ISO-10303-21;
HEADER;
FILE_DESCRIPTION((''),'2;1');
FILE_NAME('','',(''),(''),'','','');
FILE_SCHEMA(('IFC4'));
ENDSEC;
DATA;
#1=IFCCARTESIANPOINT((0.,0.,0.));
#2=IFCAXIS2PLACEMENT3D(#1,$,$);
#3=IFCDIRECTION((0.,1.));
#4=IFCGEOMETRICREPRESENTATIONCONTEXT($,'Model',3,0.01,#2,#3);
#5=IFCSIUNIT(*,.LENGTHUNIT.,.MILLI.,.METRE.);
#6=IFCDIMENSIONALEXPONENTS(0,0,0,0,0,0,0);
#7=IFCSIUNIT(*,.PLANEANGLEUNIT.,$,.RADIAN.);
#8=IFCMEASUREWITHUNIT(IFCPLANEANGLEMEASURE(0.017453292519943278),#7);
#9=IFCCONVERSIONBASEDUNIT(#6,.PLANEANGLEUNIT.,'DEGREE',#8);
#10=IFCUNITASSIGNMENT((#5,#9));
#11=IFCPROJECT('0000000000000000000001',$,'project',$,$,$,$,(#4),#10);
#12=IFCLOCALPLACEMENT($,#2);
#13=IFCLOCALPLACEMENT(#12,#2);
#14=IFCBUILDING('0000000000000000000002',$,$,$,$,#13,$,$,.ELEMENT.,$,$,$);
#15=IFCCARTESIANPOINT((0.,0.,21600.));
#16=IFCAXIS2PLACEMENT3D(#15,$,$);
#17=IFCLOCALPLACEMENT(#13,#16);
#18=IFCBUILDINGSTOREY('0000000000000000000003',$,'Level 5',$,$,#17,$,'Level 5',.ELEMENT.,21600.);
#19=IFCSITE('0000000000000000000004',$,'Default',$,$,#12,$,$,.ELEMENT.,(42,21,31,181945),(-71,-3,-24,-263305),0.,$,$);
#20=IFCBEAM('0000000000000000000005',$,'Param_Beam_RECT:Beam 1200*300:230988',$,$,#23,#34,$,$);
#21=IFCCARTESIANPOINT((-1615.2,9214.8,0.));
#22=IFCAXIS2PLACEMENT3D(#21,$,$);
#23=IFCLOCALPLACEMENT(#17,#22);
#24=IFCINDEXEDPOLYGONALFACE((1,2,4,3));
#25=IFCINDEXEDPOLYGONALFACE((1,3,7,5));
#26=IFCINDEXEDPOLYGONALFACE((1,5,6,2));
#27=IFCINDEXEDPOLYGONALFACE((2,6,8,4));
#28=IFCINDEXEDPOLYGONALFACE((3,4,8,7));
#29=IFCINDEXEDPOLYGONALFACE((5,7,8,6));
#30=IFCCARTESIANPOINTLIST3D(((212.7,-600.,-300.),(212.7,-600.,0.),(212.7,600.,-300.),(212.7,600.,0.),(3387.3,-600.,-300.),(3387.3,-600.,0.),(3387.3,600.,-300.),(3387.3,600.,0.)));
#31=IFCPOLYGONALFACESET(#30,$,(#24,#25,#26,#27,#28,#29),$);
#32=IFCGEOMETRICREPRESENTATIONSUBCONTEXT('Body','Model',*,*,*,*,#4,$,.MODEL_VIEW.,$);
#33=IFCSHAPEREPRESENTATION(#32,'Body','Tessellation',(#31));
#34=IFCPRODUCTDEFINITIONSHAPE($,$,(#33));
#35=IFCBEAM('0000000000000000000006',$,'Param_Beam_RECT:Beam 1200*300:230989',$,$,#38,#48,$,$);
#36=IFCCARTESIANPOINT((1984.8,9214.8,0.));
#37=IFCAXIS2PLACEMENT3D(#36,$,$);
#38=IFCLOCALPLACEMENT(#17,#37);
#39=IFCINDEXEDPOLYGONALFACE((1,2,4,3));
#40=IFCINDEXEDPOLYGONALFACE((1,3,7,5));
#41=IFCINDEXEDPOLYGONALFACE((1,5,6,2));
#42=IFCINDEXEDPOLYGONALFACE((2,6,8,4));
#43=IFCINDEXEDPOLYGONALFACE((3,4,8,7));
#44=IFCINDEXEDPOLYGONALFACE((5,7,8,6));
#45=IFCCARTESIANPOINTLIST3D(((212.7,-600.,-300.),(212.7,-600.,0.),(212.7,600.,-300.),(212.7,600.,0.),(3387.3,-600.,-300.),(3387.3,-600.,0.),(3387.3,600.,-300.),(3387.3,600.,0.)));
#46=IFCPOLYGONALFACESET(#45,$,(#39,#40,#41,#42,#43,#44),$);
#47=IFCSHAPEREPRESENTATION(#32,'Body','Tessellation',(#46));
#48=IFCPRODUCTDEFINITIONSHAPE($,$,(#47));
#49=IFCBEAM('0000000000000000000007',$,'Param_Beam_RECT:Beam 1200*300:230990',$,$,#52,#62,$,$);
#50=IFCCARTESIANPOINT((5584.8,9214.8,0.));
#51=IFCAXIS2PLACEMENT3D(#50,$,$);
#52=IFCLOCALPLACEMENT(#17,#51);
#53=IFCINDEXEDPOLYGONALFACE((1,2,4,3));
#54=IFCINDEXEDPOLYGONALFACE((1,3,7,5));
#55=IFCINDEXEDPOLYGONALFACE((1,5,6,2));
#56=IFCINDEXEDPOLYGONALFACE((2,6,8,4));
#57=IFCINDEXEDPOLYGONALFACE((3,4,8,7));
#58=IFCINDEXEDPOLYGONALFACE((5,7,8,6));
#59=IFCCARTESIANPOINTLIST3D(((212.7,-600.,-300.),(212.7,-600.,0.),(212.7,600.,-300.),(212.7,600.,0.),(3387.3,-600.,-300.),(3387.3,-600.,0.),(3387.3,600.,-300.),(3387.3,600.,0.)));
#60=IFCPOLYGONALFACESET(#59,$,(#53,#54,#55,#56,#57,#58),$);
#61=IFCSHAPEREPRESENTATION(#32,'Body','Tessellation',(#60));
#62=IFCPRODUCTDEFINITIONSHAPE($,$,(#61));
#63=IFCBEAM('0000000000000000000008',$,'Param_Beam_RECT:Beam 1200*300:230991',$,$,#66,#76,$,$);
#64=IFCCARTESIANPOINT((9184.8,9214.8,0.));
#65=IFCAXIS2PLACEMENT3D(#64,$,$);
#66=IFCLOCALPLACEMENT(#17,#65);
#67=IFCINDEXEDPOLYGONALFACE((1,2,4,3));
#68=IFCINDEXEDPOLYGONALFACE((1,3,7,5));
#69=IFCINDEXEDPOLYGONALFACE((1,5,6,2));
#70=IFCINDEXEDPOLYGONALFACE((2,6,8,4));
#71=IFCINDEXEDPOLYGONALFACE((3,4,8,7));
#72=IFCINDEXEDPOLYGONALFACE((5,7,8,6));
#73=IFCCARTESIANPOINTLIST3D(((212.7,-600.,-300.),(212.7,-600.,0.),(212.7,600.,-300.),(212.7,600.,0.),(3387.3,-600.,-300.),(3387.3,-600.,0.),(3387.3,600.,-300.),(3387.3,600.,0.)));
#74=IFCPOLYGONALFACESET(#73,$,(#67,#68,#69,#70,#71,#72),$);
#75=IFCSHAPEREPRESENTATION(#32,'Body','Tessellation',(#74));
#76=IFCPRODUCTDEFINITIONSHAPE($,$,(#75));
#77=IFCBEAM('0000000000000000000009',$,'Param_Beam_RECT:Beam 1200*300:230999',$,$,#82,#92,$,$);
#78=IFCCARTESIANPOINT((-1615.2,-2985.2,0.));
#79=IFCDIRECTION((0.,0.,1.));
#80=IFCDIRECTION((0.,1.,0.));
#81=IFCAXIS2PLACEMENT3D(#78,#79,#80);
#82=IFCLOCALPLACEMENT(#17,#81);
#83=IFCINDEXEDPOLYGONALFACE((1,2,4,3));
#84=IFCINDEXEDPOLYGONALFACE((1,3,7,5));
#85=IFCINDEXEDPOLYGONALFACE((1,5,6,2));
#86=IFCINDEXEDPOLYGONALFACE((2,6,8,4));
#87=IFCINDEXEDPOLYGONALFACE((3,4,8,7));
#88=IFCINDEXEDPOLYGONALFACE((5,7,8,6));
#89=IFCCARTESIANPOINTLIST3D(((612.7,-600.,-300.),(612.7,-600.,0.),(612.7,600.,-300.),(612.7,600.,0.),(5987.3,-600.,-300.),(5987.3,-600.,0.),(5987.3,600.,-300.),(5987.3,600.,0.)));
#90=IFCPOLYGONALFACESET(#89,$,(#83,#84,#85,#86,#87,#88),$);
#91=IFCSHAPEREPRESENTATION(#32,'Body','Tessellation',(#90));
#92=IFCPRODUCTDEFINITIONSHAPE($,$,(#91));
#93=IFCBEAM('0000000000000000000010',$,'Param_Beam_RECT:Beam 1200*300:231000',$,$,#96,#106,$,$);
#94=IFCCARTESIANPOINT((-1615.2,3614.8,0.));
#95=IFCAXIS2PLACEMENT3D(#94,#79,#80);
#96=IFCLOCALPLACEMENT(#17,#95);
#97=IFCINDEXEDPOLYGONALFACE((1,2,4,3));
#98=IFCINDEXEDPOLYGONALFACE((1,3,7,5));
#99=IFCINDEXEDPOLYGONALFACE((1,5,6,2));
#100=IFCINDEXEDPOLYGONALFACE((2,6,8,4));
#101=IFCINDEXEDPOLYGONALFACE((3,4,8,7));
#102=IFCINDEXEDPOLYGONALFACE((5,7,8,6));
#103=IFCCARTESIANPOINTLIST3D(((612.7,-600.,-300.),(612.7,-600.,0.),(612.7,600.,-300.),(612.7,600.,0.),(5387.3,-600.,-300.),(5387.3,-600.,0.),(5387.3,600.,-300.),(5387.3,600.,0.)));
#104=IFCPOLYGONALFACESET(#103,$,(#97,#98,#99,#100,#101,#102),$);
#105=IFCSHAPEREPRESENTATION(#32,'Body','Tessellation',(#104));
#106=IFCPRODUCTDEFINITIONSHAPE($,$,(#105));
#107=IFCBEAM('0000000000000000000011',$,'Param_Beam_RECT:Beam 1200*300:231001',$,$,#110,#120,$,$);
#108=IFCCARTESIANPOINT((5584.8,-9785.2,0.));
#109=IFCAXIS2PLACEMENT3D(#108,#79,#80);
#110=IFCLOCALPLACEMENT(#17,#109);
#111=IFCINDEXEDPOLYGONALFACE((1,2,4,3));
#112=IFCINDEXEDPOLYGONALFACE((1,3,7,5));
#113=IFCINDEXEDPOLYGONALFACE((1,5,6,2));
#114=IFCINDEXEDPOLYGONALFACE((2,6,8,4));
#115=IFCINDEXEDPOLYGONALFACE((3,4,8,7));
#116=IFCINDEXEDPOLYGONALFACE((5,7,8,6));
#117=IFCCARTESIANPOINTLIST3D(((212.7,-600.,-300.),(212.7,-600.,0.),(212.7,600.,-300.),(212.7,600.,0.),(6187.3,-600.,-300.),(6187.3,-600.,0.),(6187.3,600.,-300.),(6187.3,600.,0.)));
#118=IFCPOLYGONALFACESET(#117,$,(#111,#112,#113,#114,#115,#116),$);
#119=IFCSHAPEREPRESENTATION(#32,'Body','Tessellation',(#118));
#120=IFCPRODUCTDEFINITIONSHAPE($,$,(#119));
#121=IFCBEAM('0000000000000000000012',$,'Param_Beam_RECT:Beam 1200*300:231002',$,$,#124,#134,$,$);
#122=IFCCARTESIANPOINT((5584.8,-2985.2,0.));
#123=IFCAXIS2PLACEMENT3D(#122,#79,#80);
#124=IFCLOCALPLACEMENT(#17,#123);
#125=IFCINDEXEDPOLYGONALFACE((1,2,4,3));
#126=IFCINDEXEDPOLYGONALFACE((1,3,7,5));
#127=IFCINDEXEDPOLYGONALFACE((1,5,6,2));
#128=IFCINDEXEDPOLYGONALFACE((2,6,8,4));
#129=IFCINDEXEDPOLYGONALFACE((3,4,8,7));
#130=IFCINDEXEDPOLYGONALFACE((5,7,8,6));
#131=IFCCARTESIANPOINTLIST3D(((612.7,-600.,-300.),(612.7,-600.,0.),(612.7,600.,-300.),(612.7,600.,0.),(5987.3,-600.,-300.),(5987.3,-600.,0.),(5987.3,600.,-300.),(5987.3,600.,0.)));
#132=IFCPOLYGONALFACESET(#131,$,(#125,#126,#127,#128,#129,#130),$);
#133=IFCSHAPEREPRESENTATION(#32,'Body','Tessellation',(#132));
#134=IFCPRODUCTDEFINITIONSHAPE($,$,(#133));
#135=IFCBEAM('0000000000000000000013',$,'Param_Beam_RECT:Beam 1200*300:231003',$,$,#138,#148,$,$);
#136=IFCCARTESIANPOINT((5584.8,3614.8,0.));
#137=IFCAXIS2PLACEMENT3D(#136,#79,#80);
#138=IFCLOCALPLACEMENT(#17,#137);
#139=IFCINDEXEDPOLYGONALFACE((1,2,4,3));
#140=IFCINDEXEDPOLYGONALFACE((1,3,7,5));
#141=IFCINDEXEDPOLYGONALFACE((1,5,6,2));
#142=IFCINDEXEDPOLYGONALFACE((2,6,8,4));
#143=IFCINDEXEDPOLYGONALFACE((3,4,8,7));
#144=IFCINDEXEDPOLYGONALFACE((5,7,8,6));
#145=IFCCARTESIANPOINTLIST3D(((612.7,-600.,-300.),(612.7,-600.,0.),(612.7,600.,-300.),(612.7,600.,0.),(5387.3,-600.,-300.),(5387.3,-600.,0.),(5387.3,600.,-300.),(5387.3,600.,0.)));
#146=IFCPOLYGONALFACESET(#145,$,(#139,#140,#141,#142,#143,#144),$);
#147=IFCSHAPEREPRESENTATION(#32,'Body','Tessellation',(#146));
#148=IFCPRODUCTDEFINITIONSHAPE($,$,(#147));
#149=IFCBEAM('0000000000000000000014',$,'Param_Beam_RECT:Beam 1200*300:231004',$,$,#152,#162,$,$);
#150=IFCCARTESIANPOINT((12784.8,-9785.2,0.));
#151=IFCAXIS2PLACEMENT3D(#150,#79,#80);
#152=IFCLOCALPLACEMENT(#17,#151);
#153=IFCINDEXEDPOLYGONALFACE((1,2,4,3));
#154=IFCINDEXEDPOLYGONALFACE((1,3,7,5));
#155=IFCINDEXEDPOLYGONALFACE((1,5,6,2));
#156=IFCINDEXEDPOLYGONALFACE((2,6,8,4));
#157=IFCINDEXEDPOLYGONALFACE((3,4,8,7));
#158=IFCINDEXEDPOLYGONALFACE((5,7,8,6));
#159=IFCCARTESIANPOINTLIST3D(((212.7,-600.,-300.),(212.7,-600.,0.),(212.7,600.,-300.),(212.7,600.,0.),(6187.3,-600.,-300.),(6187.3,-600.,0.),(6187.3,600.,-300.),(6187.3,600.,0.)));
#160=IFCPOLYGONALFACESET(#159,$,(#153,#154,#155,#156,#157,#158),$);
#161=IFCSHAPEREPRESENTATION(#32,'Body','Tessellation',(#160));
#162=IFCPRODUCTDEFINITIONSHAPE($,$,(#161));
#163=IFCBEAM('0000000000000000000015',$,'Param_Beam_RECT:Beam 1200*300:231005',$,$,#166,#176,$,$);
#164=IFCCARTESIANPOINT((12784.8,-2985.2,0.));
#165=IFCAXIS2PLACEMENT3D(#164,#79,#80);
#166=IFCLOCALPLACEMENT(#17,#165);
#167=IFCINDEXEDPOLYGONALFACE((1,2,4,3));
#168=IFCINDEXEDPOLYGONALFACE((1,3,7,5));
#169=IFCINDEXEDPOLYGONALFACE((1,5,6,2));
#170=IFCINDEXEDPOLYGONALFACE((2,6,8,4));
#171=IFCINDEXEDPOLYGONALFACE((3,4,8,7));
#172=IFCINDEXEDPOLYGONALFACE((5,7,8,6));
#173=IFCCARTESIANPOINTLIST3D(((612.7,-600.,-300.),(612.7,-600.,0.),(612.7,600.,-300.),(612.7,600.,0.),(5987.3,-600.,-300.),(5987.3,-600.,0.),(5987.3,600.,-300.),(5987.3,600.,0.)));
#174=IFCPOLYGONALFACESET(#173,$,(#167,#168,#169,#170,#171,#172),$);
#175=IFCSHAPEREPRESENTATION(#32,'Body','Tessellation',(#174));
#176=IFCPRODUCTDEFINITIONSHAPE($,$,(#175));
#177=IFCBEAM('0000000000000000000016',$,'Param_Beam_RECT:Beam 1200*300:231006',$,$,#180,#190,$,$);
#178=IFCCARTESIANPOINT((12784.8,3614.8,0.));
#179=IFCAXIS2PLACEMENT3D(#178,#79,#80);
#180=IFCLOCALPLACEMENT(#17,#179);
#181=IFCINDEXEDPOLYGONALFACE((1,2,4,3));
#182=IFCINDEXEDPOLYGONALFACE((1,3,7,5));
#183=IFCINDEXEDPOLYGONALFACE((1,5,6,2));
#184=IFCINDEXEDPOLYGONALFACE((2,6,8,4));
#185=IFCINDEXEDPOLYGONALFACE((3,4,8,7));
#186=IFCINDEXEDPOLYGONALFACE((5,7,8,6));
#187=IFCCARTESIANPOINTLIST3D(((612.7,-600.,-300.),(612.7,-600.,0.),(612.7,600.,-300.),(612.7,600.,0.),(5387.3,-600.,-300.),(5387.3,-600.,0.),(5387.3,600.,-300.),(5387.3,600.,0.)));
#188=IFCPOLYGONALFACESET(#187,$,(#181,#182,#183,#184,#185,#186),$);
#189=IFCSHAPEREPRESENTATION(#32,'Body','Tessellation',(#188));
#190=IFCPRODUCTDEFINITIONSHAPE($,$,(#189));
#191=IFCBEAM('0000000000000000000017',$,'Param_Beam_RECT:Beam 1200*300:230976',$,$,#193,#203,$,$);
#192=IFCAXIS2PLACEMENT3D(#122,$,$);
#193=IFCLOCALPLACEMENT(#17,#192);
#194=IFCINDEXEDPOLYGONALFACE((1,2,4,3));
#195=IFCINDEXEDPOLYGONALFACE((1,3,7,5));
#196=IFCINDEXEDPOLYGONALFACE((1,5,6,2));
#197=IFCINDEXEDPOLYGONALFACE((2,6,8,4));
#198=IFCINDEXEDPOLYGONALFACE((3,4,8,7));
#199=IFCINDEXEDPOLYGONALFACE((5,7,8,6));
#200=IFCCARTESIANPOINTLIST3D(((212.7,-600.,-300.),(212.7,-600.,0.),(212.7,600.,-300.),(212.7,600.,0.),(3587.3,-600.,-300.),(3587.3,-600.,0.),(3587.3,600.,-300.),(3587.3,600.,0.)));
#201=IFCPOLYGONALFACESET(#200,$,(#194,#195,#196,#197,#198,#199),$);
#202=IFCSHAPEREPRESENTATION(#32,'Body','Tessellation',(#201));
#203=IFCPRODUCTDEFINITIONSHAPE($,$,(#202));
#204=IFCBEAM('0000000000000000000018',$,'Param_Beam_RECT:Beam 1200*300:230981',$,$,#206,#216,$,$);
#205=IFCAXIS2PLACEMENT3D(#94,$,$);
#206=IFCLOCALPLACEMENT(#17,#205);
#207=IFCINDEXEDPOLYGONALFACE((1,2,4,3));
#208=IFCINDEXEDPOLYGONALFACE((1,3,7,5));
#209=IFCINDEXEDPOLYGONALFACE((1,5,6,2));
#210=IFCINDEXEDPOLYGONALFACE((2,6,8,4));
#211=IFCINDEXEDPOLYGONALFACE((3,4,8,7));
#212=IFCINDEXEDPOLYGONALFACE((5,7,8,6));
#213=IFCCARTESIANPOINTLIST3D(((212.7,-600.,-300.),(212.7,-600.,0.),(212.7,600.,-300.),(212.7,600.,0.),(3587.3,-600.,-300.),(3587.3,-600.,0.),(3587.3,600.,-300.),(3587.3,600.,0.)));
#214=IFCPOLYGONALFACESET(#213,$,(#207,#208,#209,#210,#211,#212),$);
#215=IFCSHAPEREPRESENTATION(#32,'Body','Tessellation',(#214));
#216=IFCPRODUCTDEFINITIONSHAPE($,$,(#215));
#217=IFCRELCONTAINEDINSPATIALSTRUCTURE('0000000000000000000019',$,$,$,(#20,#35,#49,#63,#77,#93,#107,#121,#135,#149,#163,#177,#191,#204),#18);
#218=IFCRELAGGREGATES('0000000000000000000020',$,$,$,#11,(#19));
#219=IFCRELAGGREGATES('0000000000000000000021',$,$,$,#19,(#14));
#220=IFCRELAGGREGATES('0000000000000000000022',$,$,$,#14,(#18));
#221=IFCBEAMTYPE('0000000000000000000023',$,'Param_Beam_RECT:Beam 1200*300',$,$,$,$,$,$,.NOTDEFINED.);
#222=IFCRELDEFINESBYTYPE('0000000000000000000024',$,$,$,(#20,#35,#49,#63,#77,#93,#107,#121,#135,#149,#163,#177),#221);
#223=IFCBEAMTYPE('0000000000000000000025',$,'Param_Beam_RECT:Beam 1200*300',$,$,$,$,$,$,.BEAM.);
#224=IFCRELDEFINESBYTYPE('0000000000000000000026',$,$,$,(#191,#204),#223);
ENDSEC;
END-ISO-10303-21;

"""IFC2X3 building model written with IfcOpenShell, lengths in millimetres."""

from ifc_helpers import new_model, entity, si_unit, converted_unit, direction, frame, frame_2d, origin, origin_2d_with_axis, place, context, subcontext, project, spatial, rectangle, extrude, type_object, element, save


model = new_model("IFC2X3")

# Units and contexts
model_context = context("Model", 3, precision=0.01, world=origin(), true_north=direction((0.0, 1.0)))
body_context = subcontext(model_context, "Body", "Model", "MODEL_VIEW")
ifc_project = project(units=[si_unit("LENGTHUNIT", "METRE", prefix="MILLI"), converted_unit("PLANEANGLEUNIT", "DEGREE", entity("IfcPlaneAngleMeasure", 0.017453292519943278), si_unit("PLANEANGLEUNIT", "RADIAN"), dimensions=[0, 0, 0, 0, 0, 0, 0])], contexts=[model_context])

# Site, building, storey
site_placement = place(None, origin())
site = spatial("IfcSite", under=ifc_project, at=site_placement, Name="Default", CompositionType="ELEMENT", RefLatitude=(42, 21, 31, 181945), RefLongitude=(-71, -3, -24, -263305), RefElevation=0.0)
building_placement = place(site_placement, origin())
building = spatial("IfcBuilding", under=site, at=building_placement, CompositionType="ELEMENT")
storey_placement = place(building_placement, frame((0.0, 0.0, 21600.0)))
storey = spatial("IfcBuildingStorey", under=building, at=storey_placement, Name="Level 5", LongName="Level 5", CompositionType="ELEMENT", Elevation=21600.0)

# Beams
beam_type_1 = type_object("IfcBeamType", Name="Param_Beam_RECT:Beam 1200*300", PredefinedType="NOTDEFINED")
beam_1_placement = place(storey_placement, frame((-1615.2, 9214.8, 0.0)))
element("IfcBeam", 1, at=beam_1_placement, inside=storey, type_object=beam_type_1, Name="Param_Beam_RECT:Beam 1200*300:230988", context=body_context, shape_type="SweptSolid", body=[
    extrude(rectangle(XDim=300.0, YDim=1200.0, at=frame_2d((0.0, 0.0), x_axis=(1.0, 0.0))), frame((212.7, 0.0, -150.0), z_axis=(1.0, 0.0, 0.0), x_axis=(0.0, 0.0, -1.0)), (0.0, 0.0, 1.0), 3174.6),
])
beam_2_placement = place(storey_placement, frame((1984.8, 9214.8, 0.0)))
element("IfcBeam", 2, at=beam_2_placement, inside=storey, type_object=beam_type_1, Name="Param_Beam_RECT:Beam 1200*300:230989", context=body_context, shape_type="SweptSolid", body=[
    extrude(rectangle(XDim=300.0, YDim=1200.0, at=origin_2d_with_axis()), frame((212.7, 0.0, -150.0), z_axis=(1.0, 0.0, 0.0), x_axis=(0.0, 0.0, -1.0)), (0.0, 0.0, 1.0), 3174.6),
])
for number, where, name in (
    (3, (5584.8, 9214.8, 0.0), "Param_Beam_RECT:Beam 1200*300:230990"),
    (4, (9184.8, 9214.8, 0.0), "Param_Beam_RECT:Beam 1200*300:230991"),
):
    element("IfcBeam", number, at=place(storey_placement, frame(where)), inside=storey, type_object=beam_type_1, Name=name, context=body_context, shape_type="SweptSolid", body=[
        extrude(rectangle(XDim=300.0, YDim=1200.0, at=frame_2d((0.0, 0.0), x_axis=(1.0, 0.0))), frame((212.7, 0.0, -150.0), z_axis=(1.0, 0.0, 0.0), x_axis=(0.0, 0.0, -1.0)), (0.0, 0.0, 1.0), 3174.6),
    ])
beam_3_placement = place(storey_placement, frame((-1615.2, -2985.2, 0.0), z_axis=(0.0, 0.0, 1.0), x_axis=(0.0, 1.0, 0.0)))
element("IfcBeam", 5, at=beam_3_placement, inside=storey, type_object=beam_type_1, Name="Param_Beam_RECT:Beam 1200*300:230999", context=body_context, shape_type="SweptSolid", body=[
    extrude(rectangle(XDim=300.0, YDim=1200.0, at=frame_2d((0.0, 0.0), x_axis=(1.0, 0.0))), frame((612.7, 0.0, -150.0), z_axis=(1.0, 0.0, 0.0), x_axis=(0.0, 0.0, -1.0)), (0.0, 0.0, 1.0), 5374.6),
])
beam_4_placement = place(storey_placement, frame((-1615.2, 3614.8, 0.0), z_axis=(0.0, 0.0, 1.0), x_axis=(0.0, 1.0, 0.0)))
element("IfcBeam", 6, at=beam_4_placement, inside=storey, type_object=beam_type_1, Name="Param_Beam_RECT:Beam 1200*300:231000", context=body_context, shape_type="SweptSolid", body=[
    extrude(rectangle(XDim=300.0, YDim=1200.0, at=frame_2d((0.0, 0.0), x_axis=(1.0, 0.0))), frame((612.7, 0.0, -150.0), z_axis=(1.0, 0.0, 0.0), x_axis=(0.0, 0.0, -1.0)), (0.0, 0.0, 1.0), 4774.6),
])
beam_5_placement = place(storey_placement, frame((5584.8, -9785.2, 0.0), z_axis=(0.0, 0.0, 1.0), x_axis=(0.0, 1.0, 0.0)))
element("IfcBeam", 7, at=beam_5_placement, inside=storey, type_object=beam_type_1, Name="Param_Beam_RECT:Beam 1200*300:231001", context=body_context, shape_type="SweptSolid", body=[
    extrude(rectangle(XDim=300.0, YDim=1200.0, at=frame_2d((0.0, 0.0), x_axis=(1.0, 0.0))), frame((212.7, 0.0, -150.0), z_axis=(1.0, 0.0, 0.0), x_axis=(0.0, 0.0, -1.0)), (0.0, 0.0, 1.0), 5974.6),
])
beam_6_placement = place(storey_placement, frame((5584.8, -2985.2, 0.0), z_axis=(0.0, 0.0, 1.0), x_axis=(0.0, 1.0, 0.0)))
element("IfcBeam", 8, at=beam_6_placement, inside=storey, type_object=beam_type_1, Name="Param_Beam_RECT:Beam 1200*300:231002", context=body_context, shape_type="SweptSolid", body=[
    extrude(rectangle(XDim=300.0, YDim=1200.0, at=frame_2d((0.0, 0.0), x_axis=(1.0, 0.0))), frame((612.7, 0.0, -150.0), z_axis=(1.0, 0.0, 0.0), x_axis=(0.0, 0.0, -1.0)), (0.0, 0.0, 1.0), 5374.6),
])
beam_7_placement = place(storey_placement, frame((5584.8, 3614.8, 0.0), z_axis=(0.0, 0.0, 1.0), x_axis=(0.0, 1.0, 0.0)))
element("IfcBeam", 9, at=beam_7_placement, inside=storey, type_object=beam_type_1, Name="Param_Beam_RECT:Beam 1200*300:231003", context=body_context, shape_type="SweptSolid", body=[
    extrude(rectangle(XDim=300.0, YDim=1200.0, at=frame_2d((0.0, 0.0), x_axis=(1.0, 0.0))), frame((612.7, 0.0, -150.0), z_axis=(1.0, 0.0, 0.0), x_axis=(0.0, 0.0, -1.0)), (0.0, 0.0, 1.0), 4774.6),
])
beam_8_placement = place(storey_placement, frame((12784.8, -9785.2, 0.0), z_axis=(0.0, 0.0, 1.0), x_axis=(0.0, 1.0, 0.0)))
element("IfcBeam", 10, at=beam_8_placement, inside=storey, type_object=beam_type_1, Name="Param_Beam_RECT:Beam 1200*300:231004", context=body_context, shape_type="SweptSolid", body=[
    extrude(rectangle(XDim=300.0, YDim=1200.0, at=origin_2d_with_axis()), frame((212.7, 0.0, -150.0), z_axis=(1.0, 0.0, 0.0), x_axis=(0.0, 0.0, -1.0)), (0.0, 0.0, 1.0), 5974.6),
])
beam_9_placement = place(storey_placement, frame((12784.8, -2985.2, 0.0), z_axis=(0.0, 0.0, 1.0), x_axis=(0.0, 1.0, 0.0)))
element("IfcBeam", 11, at=beam_9_placement, inside=storey, type_object=beam_type_1, Name="Param_Beam_RECT:Beam 1200*300:231005", context=body_context, shape_type="SweptSolid", body=[
    extrude(rectangle(XDim=300.0, YDim=1200.0, at=frame_2d((0.0, 0.0), x_axis=(1.0, 0.0))), frame((612.7, 0.0, -150.0), z_axis=(1.0, 0.0, 0.0), x_axis=(0.0, 0.0, -1.0)), (0.0, 0.0, 1.0), 5374.6),
])
beam_10_placement = place(storey_placement, frame((12784.8, 3614.8, 0.0), z_axis=(0.0, 0.0, 1.0), x_axis=(0.0, 1.0, 0.0)))
element("IfcBeam", 12, at=beam_10_placement, inside=storey, type_object=beam_type_1, Name="Param_Beam_RECT:Beam 1200*300:231006", context=body_context, shape_type="SweptSolid", body=[
    extrude(rectangle(XDim=300.0, YDim=1200.0, at=origin_2d_with_axis()), frame((612.7, 0.0, -150.0), z_axis=(1.0, 0.0, 0.0), x_axis=(0.0, 0.0, -1.0)), (0.0, 0.0, 1.0), 4774.6),
])
beam_type_2 = type_object("IfcBeamType", Name="Param_Beam_RECT:Beam 1200*300", PredefinedType="BEAM")
beam_11_placement = place(storey_placement, frame((5584.8, -2985.2, 0.0)))
element("IfcBeam", 13, at=beam_11_placement, inside=storey, type_object=beam_type_2, Name="Param_Beam_RECT:Beam 1200*300:230976", context=body_context, shape_type="SweptSolid", body=[
    extrude(rectangle(XDim=300.0, YDim=1200.0, at=frame_2d((0.0, 0.0), x_axis=(1.0, 0.0))), frame((212.7, 0.0, -150.0), z_axis=(1.0, 0.0, 0.0), x_axis=(0.0, 0.0, -1.0)), (0.0, 0.0, 1.0), 3374.6),
])
beam_12_placement = place(storey_placement, frame((-1615.2, 3614.8, 0.0)))
element("IfcBeam", 14, at=beam_12_placement, inside=storey, type_object=beam_type_2, Name="Param_Beam_RECT:Beam 1200*300:230981", context=body_context, shape_type="SweptSolid", body=[
    extrude(rectangle(XDim=300.0, YDim=1200.0, at=frame_2d((0.0, 0.0), x_axis=(1.0, 0.0))), frame((212.7, 0.0, -150.0), z_axis=(1.0, 0.0, 0.0), x_axis=(0.0, 0.0, -1.0)), (0.0, 0.0, 1.0), 3374.6),
])

save(model, "model.ifc")
